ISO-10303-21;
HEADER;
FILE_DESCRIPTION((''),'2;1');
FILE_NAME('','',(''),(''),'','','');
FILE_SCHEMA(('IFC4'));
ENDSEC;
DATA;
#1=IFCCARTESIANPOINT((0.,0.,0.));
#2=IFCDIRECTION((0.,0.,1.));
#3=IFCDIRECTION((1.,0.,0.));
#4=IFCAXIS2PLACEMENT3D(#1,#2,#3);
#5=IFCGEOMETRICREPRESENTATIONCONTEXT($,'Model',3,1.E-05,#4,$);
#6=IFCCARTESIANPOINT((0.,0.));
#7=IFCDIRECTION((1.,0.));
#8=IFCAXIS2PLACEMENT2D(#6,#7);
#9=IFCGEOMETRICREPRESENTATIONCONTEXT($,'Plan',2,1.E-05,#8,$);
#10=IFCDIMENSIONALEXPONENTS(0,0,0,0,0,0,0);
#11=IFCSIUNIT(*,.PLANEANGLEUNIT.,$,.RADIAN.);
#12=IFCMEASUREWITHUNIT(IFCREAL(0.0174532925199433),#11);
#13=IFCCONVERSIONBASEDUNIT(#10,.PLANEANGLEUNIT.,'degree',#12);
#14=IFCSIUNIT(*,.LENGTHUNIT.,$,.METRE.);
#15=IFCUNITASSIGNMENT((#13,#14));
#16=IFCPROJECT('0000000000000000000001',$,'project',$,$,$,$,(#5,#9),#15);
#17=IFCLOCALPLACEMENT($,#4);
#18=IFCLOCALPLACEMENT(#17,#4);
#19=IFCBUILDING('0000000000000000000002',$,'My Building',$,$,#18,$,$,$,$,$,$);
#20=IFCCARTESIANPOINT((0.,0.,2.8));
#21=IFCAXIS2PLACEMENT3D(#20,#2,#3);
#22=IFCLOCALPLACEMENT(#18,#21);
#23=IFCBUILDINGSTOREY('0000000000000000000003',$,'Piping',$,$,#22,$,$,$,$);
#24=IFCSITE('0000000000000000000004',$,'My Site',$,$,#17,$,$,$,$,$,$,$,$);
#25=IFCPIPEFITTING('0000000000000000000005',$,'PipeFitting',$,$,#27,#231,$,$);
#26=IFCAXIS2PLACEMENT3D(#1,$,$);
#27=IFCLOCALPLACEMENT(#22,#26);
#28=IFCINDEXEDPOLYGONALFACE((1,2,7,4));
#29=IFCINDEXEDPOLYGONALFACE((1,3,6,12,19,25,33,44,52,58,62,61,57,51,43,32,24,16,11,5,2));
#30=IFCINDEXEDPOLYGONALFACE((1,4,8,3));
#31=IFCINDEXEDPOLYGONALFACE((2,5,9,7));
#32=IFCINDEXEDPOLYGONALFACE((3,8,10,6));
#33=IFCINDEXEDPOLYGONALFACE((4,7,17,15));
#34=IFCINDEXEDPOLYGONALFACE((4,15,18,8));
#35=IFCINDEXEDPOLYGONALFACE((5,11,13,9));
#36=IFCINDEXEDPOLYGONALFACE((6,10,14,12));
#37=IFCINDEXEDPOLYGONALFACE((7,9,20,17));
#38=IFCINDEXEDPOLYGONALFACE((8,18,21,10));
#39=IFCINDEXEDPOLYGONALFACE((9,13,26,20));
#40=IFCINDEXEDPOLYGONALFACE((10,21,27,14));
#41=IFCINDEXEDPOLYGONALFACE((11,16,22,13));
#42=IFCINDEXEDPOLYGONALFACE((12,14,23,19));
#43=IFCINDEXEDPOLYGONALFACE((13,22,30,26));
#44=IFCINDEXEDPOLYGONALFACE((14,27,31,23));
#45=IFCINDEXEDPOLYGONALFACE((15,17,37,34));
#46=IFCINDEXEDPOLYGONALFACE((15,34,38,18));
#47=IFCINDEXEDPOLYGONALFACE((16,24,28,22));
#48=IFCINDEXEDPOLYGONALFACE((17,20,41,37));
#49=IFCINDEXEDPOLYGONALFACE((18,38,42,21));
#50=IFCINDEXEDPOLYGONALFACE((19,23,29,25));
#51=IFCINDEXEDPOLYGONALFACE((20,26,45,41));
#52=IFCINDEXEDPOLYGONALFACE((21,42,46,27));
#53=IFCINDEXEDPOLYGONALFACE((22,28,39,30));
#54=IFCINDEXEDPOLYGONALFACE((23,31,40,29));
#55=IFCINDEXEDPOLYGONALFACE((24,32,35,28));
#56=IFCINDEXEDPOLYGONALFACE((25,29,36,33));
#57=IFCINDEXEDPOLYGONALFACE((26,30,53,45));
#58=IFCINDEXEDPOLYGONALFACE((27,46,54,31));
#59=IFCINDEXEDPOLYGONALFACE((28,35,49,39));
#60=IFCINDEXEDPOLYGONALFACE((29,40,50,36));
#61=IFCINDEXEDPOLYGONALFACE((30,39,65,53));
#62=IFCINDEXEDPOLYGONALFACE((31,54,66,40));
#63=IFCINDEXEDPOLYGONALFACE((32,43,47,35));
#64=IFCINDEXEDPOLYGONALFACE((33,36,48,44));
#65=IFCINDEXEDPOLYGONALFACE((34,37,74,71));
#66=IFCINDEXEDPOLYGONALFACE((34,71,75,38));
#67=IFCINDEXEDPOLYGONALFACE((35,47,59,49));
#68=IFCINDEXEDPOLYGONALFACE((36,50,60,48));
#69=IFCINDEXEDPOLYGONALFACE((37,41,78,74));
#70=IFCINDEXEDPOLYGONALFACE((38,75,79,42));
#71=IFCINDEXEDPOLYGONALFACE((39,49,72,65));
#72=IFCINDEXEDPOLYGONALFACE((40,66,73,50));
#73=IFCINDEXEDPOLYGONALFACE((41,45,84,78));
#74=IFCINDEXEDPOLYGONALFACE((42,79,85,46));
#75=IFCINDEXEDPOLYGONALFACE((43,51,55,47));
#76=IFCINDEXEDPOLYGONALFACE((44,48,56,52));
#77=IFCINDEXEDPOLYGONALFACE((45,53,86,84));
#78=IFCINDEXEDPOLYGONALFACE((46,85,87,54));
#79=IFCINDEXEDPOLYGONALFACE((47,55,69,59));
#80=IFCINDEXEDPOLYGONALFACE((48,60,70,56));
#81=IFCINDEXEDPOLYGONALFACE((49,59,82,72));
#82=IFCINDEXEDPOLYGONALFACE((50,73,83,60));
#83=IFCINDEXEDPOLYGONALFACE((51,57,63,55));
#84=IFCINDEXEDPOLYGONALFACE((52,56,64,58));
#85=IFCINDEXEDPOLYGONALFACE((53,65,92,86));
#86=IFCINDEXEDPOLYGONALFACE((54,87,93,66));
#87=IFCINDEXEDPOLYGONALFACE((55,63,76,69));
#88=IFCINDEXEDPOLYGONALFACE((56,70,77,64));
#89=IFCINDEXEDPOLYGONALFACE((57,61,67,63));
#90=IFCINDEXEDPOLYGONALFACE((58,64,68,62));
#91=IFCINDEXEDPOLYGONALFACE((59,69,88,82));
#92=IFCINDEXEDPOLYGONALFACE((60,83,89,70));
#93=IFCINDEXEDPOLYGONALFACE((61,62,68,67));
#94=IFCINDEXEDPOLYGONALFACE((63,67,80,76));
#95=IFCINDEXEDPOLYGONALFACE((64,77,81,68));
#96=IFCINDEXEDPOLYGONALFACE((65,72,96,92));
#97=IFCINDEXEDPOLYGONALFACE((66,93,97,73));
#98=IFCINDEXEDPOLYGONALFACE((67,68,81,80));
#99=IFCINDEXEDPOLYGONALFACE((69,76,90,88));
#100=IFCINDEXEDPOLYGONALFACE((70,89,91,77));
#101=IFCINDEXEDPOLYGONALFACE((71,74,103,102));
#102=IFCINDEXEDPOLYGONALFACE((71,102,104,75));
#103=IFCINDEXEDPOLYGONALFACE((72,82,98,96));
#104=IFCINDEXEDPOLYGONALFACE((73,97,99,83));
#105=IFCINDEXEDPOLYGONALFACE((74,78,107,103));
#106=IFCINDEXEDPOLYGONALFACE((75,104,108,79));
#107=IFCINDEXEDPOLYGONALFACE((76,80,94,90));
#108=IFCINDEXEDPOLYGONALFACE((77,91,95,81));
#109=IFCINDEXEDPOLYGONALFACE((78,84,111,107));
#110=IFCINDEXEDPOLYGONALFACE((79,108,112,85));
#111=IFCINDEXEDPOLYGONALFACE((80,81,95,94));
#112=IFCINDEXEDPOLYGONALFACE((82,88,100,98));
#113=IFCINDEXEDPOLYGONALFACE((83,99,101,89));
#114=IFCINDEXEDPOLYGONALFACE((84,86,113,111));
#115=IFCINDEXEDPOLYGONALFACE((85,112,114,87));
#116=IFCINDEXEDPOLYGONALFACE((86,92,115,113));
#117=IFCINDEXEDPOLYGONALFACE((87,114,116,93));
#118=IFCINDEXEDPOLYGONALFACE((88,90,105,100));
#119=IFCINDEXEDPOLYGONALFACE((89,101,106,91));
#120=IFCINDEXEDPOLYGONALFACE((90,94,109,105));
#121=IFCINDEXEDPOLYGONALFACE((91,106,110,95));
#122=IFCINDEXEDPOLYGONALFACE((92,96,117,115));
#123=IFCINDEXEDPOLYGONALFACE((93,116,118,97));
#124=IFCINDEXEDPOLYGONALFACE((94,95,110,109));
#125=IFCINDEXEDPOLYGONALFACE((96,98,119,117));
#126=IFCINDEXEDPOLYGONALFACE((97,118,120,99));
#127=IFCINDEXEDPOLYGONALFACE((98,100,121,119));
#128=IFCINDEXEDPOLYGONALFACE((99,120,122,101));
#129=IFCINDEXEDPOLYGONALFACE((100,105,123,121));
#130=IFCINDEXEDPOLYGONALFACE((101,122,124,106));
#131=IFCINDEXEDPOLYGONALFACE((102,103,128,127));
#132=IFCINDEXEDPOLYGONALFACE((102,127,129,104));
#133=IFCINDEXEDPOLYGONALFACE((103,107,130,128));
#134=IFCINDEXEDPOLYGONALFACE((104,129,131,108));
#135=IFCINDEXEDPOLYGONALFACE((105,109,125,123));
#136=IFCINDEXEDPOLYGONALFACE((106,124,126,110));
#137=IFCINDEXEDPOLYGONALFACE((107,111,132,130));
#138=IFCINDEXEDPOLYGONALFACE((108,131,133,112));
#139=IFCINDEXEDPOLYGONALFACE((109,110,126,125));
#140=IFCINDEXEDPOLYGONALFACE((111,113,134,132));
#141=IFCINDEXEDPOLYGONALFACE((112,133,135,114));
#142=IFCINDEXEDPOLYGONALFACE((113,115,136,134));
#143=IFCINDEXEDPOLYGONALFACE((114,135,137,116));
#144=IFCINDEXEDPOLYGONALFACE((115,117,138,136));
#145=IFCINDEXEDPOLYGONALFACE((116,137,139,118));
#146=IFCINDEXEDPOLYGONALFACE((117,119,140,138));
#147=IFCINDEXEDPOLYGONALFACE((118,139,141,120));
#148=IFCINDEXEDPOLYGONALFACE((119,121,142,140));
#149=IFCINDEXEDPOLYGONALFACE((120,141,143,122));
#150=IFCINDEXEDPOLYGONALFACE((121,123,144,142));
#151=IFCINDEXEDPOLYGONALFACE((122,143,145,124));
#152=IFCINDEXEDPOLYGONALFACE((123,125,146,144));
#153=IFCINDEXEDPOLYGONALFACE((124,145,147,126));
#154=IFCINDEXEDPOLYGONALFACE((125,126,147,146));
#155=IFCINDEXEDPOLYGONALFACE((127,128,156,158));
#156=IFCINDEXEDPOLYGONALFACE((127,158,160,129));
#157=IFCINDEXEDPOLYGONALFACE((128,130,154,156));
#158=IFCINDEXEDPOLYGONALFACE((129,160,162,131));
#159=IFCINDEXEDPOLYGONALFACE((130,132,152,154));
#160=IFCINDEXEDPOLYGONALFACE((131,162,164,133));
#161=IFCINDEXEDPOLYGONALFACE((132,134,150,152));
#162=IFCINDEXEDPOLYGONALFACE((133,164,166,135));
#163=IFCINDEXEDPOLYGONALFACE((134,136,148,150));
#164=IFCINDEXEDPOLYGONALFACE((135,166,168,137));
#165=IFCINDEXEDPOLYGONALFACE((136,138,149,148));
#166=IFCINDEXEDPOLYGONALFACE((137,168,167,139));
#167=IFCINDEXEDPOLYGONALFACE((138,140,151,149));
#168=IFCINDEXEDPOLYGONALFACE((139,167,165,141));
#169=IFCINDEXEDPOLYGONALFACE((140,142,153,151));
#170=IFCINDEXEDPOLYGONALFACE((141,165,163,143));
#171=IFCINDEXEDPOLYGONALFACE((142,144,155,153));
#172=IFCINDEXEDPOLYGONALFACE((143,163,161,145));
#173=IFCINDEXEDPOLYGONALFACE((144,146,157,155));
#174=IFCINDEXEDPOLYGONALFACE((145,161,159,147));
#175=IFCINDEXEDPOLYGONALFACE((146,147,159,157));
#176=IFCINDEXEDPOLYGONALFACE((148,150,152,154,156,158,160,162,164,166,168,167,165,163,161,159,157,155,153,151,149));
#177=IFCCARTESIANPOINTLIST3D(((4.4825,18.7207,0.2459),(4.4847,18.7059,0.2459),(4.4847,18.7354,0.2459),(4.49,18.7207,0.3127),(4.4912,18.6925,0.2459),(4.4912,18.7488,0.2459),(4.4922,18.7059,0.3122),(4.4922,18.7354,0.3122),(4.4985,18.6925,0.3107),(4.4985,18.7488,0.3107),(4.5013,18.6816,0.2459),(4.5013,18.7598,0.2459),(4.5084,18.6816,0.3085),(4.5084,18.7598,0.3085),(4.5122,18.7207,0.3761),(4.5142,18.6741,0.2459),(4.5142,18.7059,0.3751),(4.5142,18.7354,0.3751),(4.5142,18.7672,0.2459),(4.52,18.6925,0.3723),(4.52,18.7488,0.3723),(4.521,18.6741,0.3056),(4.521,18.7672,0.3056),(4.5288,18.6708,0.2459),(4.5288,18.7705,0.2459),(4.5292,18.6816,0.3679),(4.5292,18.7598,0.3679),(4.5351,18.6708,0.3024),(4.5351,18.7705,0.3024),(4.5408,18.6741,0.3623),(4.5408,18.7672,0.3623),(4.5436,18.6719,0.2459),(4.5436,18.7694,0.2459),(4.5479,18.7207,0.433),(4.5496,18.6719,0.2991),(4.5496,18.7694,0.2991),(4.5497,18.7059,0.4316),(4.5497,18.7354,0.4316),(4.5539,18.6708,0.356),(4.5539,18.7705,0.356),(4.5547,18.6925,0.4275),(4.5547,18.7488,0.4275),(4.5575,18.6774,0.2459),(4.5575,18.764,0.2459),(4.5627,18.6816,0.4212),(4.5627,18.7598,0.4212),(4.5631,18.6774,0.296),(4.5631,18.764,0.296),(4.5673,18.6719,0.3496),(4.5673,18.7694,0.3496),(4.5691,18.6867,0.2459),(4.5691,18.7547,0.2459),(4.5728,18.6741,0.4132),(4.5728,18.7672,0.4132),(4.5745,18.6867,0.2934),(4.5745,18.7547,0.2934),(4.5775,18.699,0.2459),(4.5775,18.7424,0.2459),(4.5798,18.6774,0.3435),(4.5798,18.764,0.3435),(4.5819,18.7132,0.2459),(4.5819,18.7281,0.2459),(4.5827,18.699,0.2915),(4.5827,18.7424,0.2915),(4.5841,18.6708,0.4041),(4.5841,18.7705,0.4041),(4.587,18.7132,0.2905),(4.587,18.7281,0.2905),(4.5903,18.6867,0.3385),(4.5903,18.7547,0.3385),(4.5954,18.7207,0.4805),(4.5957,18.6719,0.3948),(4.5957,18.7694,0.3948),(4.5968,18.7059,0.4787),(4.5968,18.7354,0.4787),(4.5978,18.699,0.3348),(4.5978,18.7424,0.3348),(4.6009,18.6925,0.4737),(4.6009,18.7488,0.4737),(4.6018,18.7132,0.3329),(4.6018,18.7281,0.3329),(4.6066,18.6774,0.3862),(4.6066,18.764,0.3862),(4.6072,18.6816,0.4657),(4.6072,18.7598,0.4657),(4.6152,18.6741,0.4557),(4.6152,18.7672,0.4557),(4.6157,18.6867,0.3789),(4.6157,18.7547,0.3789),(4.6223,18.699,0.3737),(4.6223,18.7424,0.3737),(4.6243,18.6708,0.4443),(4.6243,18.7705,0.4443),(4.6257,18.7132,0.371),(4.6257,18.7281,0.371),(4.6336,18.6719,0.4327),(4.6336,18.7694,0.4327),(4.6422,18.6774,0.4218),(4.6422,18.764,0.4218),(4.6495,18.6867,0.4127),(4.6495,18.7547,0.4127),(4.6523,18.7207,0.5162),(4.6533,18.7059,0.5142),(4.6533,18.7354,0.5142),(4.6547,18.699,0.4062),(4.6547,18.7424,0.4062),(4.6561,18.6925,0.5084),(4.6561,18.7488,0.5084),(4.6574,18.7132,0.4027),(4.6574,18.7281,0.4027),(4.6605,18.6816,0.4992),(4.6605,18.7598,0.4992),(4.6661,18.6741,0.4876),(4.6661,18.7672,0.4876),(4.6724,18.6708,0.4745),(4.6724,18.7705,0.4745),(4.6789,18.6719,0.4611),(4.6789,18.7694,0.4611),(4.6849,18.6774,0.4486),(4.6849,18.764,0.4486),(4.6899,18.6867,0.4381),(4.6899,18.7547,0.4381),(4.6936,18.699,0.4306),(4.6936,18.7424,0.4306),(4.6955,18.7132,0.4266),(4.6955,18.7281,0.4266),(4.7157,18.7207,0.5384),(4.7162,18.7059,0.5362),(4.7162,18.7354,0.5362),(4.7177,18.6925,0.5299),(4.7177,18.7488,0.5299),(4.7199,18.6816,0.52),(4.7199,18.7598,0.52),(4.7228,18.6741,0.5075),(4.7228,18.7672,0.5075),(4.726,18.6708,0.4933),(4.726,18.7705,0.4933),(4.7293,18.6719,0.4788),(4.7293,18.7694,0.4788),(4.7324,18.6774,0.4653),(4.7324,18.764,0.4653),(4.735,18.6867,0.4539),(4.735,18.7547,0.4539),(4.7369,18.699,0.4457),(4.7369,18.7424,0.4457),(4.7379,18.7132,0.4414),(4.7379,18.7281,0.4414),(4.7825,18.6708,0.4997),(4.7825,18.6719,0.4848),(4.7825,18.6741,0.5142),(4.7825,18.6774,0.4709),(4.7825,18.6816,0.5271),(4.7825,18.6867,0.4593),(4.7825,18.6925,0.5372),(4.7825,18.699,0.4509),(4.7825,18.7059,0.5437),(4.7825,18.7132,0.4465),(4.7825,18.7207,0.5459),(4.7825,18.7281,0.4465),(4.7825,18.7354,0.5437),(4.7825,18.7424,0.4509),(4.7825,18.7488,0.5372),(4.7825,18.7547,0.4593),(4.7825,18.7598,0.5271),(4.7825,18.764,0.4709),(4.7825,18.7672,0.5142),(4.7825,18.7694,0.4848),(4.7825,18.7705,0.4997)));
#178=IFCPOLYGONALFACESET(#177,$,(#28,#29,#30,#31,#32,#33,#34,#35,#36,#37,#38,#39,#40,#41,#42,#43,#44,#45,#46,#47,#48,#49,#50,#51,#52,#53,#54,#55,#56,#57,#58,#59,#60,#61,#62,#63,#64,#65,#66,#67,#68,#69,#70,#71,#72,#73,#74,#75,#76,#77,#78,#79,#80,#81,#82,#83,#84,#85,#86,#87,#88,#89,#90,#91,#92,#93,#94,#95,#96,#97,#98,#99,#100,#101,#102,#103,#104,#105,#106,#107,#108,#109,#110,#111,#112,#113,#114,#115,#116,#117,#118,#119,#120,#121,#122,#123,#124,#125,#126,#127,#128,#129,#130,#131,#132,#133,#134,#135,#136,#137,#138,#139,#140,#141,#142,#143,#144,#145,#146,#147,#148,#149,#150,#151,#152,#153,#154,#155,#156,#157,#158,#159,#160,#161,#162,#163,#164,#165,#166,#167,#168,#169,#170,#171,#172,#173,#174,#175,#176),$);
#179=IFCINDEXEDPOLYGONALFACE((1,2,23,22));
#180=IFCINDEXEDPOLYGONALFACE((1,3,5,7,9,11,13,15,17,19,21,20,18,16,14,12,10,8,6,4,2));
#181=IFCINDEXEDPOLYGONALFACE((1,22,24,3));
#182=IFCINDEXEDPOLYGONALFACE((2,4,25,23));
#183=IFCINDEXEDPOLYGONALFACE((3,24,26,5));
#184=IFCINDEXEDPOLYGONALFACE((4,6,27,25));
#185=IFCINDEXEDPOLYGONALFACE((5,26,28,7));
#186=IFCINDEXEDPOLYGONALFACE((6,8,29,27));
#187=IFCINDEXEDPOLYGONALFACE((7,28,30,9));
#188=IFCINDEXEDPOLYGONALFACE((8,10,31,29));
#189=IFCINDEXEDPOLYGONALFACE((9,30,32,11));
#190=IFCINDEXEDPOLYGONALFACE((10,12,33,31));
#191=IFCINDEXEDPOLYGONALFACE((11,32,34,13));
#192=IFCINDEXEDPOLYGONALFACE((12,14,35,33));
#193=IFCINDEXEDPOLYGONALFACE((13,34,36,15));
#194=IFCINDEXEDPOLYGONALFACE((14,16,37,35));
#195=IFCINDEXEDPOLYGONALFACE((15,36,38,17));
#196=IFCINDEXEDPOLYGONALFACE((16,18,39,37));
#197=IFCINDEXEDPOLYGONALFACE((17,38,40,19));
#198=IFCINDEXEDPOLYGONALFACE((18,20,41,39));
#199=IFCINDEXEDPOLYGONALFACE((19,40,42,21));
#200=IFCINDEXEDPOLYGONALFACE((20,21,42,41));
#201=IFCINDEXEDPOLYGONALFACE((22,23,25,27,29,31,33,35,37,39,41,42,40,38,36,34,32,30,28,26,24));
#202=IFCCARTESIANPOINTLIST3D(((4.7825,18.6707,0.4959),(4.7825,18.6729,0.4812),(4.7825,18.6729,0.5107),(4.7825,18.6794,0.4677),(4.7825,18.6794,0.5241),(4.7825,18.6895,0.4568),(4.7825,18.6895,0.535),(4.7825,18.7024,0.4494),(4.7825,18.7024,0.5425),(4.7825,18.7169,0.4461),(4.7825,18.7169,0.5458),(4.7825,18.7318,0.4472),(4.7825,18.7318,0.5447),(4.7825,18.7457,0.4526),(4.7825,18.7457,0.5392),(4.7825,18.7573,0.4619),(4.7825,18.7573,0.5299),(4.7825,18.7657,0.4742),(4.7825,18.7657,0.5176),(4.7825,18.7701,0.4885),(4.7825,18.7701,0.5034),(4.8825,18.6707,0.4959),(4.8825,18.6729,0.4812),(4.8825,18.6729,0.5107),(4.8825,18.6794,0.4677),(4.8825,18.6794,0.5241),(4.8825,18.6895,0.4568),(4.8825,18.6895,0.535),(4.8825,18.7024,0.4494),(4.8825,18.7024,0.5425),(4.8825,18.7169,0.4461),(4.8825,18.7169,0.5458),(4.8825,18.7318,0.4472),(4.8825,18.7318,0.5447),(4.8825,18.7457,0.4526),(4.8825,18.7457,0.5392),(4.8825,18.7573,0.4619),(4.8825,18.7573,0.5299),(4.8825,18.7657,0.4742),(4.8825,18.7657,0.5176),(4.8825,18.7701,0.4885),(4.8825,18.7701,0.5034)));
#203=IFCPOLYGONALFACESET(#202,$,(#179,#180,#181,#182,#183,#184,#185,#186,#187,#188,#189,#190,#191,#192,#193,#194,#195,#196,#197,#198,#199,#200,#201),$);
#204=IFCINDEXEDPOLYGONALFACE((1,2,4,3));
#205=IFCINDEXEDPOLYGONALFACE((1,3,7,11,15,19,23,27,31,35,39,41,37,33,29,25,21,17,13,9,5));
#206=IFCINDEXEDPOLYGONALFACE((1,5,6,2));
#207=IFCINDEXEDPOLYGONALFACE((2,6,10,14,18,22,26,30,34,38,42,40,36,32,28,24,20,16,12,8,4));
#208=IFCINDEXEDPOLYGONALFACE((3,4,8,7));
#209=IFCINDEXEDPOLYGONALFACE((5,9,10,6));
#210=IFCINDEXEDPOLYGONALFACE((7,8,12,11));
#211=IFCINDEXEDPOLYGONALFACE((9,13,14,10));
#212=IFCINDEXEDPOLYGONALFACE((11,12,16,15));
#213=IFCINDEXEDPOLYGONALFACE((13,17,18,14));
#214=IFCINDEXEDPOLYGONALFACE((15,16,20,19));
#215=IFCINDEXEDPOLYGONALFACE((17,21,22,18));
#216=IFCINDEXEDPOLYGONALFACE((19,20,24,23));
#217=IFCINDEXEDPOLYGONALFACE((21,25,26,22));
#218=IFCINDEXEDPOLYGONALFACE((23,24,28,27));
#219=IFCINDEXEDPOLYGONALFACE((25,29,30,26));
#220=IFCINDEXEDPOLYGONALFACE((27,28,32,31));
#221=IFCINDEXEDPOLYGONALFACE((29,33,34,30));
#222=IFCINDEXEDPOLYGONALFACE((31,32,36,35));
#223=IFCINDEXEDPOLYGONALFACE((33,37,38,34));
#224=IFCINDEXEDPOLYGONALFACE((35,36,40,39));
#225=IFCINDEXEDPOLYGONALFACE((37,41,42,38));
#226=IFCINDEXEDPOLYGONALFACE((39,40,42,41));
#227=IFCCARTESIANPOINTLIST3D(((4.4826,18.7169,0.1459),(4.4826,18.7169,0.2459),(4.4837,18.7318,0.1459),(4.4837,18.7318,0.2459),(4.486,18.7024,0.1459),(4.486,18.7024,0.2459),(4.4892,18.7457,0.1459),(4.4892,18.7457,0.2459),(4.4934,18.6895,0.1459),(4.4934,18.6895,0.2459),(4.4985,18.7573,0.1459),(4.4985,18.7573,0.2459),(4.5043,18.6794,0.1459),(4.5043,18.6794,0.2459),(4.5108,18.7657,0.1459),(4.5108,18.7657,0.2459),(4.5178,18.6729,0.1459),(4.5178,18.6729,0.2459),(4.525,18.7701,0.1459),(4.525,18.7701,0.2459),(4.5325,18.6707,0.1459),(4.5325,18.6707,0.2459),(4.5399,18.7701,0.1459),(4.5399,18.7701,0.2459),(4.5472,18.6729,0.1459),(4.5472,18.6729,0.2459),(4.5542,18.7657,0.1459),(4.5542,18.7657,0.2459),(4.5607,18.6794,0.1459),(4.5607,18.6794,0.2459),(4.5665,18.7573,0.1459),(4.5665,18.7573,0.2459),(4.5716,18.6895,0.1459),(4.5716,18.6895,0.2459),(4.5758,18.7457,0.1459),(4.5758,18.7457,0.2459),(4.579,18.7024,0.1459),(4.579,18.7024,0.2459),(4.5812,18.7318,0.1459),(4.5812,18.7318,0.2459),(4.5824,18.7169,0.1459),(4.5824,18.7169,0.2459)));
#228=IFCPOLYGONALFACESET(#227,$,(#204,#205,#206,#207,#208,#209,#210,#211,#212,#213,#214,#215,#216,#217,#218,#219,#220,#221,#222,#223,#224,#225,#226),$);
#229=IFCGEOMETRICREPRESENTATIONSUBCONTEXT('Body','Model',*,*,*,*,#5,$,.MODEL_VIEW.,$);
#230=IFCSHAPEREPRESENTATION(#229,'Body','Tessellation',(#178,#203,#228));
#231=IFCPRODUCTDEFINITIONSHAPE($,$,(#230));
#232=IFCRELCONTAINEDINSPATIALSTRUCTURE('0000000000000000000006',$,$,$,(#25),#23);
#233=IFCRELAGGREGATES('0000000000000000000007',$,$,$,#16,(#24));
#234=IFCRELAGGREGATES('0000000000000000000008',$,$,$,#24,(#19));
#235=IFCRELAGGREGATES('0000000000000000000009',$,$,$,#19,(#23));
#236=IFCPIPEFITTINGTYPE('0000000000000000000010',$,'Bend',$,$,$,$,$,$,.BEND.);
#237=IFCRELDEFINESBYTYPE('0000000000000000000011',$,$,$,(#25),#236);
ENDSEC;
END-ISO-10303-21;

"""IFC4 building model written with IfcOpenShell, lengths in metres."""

from ifc_helpers import new_model, entity, si_unit, converted_unit, frame, origin_with_axes, origin_2d_with_axis, place, context, subcontext, project, spatial, circle, extrude, source, transform, mapped, type_object, type_shapes, element, save


model = new_model("IFC4")

# Units and contexts
model_context = context("Model", 3, precision=1e-05, world=origin_with_axes())
plan_context = context("Plan", 2, precision=1e-05, world=origin_2d_with_axis())
body_context = subcontext(model_context, "Body", "Model", "MODEL_VIEW")
ifc_project = project(units=[converted_unit("PLANEANGLEUNIT", "degree", entity("IfcReal", 0.0174532925199433), si_unit("PLANEANGLEUNIT", "RADIAN"), dimensions=[0, 0, 0, 0, 0, 0, 0]), si_unit("LENGTHUNIT", "METRE")], contexts=[model_context, plan_context])

# Site, building, storey
site_placement = place(None, origin_with_axes())
site = spatial("IfcSite", under=ifc_project, at=site_placement, Name="My Site")
building_placement = place(site_placement, origin_with_axes())
building = spatial("IfcBuilding", under=site, at=building_placement, Name="My Building")
storey_placement = place(building_placement, frame((0.0, 0.0, 2.8), z_axis=(0.0, 0.0, 1.0), x_axis=(1.0, 0.0, 0.0)))
storey = spatial("IfcBuildingStorey", under=building, at=storey_placement, Name="Piping")

# Pipe fitting
pipe_fitting_type_1 = type_object("IfcPipeFittingType", Name="Bend", PredefinedType="BEND")
shared_shape_1 = source(origin_with_axes(), body_context, "Body", "SolidModel", [
    entity("IfcSweptDiskSolid", entity("IfcIndexedPolyCurve", entity("IfcCartesianPointList3D", [[0.0, 0.0, 0.1], [0.0, -0.0732, 0.2768], [0.0, -0.25, 0.35]]), [entity("IfcArcIndex", [1, 2, 3])]), 0.05),
    extrude(circle(Radius=0.05), origin_with_axes(), (0.0, 0.0, 1.0), 0.1),
    extrude(circle(Radius=0.05), frame((0.0, -0.25, 0.35), z_axis=(0.0, -1.0, 0.0), x_axis=(1.0, 0.0, 0.0)), (0.0, 0.0, 1.0), 0.1),
])
type_shapes(pipe_fitting_type_1, [shared_shape_1])
for number, where, z_axis, x_axis, name in (
    (1, (4.8825, 18.7207, 0.4959), (-1.0, 0.0, 0.0), (0.0, -1.0, 0.0), "PipeFitting"),
):
    element("IfcPipeFitting", number, at=place(storey_placement, frame(where, z_axis=z_axis, x_axis=x_axis)), inside=storey, type_object=pipe_fitting_type_1, Name=name, context=body_context, shape_type="MappedRepresentation", body=[
        mapped(shared_shape_1, transform((0.0, 0.0, 0.0), x_axis=(1.0, 0.0, 0.0), y_axis=(0.0, 1.0, 0.0), z_axis=(0.0, 0.0, 1.0), scale=1.0)),
    ])

save(model, "model.ifc")
